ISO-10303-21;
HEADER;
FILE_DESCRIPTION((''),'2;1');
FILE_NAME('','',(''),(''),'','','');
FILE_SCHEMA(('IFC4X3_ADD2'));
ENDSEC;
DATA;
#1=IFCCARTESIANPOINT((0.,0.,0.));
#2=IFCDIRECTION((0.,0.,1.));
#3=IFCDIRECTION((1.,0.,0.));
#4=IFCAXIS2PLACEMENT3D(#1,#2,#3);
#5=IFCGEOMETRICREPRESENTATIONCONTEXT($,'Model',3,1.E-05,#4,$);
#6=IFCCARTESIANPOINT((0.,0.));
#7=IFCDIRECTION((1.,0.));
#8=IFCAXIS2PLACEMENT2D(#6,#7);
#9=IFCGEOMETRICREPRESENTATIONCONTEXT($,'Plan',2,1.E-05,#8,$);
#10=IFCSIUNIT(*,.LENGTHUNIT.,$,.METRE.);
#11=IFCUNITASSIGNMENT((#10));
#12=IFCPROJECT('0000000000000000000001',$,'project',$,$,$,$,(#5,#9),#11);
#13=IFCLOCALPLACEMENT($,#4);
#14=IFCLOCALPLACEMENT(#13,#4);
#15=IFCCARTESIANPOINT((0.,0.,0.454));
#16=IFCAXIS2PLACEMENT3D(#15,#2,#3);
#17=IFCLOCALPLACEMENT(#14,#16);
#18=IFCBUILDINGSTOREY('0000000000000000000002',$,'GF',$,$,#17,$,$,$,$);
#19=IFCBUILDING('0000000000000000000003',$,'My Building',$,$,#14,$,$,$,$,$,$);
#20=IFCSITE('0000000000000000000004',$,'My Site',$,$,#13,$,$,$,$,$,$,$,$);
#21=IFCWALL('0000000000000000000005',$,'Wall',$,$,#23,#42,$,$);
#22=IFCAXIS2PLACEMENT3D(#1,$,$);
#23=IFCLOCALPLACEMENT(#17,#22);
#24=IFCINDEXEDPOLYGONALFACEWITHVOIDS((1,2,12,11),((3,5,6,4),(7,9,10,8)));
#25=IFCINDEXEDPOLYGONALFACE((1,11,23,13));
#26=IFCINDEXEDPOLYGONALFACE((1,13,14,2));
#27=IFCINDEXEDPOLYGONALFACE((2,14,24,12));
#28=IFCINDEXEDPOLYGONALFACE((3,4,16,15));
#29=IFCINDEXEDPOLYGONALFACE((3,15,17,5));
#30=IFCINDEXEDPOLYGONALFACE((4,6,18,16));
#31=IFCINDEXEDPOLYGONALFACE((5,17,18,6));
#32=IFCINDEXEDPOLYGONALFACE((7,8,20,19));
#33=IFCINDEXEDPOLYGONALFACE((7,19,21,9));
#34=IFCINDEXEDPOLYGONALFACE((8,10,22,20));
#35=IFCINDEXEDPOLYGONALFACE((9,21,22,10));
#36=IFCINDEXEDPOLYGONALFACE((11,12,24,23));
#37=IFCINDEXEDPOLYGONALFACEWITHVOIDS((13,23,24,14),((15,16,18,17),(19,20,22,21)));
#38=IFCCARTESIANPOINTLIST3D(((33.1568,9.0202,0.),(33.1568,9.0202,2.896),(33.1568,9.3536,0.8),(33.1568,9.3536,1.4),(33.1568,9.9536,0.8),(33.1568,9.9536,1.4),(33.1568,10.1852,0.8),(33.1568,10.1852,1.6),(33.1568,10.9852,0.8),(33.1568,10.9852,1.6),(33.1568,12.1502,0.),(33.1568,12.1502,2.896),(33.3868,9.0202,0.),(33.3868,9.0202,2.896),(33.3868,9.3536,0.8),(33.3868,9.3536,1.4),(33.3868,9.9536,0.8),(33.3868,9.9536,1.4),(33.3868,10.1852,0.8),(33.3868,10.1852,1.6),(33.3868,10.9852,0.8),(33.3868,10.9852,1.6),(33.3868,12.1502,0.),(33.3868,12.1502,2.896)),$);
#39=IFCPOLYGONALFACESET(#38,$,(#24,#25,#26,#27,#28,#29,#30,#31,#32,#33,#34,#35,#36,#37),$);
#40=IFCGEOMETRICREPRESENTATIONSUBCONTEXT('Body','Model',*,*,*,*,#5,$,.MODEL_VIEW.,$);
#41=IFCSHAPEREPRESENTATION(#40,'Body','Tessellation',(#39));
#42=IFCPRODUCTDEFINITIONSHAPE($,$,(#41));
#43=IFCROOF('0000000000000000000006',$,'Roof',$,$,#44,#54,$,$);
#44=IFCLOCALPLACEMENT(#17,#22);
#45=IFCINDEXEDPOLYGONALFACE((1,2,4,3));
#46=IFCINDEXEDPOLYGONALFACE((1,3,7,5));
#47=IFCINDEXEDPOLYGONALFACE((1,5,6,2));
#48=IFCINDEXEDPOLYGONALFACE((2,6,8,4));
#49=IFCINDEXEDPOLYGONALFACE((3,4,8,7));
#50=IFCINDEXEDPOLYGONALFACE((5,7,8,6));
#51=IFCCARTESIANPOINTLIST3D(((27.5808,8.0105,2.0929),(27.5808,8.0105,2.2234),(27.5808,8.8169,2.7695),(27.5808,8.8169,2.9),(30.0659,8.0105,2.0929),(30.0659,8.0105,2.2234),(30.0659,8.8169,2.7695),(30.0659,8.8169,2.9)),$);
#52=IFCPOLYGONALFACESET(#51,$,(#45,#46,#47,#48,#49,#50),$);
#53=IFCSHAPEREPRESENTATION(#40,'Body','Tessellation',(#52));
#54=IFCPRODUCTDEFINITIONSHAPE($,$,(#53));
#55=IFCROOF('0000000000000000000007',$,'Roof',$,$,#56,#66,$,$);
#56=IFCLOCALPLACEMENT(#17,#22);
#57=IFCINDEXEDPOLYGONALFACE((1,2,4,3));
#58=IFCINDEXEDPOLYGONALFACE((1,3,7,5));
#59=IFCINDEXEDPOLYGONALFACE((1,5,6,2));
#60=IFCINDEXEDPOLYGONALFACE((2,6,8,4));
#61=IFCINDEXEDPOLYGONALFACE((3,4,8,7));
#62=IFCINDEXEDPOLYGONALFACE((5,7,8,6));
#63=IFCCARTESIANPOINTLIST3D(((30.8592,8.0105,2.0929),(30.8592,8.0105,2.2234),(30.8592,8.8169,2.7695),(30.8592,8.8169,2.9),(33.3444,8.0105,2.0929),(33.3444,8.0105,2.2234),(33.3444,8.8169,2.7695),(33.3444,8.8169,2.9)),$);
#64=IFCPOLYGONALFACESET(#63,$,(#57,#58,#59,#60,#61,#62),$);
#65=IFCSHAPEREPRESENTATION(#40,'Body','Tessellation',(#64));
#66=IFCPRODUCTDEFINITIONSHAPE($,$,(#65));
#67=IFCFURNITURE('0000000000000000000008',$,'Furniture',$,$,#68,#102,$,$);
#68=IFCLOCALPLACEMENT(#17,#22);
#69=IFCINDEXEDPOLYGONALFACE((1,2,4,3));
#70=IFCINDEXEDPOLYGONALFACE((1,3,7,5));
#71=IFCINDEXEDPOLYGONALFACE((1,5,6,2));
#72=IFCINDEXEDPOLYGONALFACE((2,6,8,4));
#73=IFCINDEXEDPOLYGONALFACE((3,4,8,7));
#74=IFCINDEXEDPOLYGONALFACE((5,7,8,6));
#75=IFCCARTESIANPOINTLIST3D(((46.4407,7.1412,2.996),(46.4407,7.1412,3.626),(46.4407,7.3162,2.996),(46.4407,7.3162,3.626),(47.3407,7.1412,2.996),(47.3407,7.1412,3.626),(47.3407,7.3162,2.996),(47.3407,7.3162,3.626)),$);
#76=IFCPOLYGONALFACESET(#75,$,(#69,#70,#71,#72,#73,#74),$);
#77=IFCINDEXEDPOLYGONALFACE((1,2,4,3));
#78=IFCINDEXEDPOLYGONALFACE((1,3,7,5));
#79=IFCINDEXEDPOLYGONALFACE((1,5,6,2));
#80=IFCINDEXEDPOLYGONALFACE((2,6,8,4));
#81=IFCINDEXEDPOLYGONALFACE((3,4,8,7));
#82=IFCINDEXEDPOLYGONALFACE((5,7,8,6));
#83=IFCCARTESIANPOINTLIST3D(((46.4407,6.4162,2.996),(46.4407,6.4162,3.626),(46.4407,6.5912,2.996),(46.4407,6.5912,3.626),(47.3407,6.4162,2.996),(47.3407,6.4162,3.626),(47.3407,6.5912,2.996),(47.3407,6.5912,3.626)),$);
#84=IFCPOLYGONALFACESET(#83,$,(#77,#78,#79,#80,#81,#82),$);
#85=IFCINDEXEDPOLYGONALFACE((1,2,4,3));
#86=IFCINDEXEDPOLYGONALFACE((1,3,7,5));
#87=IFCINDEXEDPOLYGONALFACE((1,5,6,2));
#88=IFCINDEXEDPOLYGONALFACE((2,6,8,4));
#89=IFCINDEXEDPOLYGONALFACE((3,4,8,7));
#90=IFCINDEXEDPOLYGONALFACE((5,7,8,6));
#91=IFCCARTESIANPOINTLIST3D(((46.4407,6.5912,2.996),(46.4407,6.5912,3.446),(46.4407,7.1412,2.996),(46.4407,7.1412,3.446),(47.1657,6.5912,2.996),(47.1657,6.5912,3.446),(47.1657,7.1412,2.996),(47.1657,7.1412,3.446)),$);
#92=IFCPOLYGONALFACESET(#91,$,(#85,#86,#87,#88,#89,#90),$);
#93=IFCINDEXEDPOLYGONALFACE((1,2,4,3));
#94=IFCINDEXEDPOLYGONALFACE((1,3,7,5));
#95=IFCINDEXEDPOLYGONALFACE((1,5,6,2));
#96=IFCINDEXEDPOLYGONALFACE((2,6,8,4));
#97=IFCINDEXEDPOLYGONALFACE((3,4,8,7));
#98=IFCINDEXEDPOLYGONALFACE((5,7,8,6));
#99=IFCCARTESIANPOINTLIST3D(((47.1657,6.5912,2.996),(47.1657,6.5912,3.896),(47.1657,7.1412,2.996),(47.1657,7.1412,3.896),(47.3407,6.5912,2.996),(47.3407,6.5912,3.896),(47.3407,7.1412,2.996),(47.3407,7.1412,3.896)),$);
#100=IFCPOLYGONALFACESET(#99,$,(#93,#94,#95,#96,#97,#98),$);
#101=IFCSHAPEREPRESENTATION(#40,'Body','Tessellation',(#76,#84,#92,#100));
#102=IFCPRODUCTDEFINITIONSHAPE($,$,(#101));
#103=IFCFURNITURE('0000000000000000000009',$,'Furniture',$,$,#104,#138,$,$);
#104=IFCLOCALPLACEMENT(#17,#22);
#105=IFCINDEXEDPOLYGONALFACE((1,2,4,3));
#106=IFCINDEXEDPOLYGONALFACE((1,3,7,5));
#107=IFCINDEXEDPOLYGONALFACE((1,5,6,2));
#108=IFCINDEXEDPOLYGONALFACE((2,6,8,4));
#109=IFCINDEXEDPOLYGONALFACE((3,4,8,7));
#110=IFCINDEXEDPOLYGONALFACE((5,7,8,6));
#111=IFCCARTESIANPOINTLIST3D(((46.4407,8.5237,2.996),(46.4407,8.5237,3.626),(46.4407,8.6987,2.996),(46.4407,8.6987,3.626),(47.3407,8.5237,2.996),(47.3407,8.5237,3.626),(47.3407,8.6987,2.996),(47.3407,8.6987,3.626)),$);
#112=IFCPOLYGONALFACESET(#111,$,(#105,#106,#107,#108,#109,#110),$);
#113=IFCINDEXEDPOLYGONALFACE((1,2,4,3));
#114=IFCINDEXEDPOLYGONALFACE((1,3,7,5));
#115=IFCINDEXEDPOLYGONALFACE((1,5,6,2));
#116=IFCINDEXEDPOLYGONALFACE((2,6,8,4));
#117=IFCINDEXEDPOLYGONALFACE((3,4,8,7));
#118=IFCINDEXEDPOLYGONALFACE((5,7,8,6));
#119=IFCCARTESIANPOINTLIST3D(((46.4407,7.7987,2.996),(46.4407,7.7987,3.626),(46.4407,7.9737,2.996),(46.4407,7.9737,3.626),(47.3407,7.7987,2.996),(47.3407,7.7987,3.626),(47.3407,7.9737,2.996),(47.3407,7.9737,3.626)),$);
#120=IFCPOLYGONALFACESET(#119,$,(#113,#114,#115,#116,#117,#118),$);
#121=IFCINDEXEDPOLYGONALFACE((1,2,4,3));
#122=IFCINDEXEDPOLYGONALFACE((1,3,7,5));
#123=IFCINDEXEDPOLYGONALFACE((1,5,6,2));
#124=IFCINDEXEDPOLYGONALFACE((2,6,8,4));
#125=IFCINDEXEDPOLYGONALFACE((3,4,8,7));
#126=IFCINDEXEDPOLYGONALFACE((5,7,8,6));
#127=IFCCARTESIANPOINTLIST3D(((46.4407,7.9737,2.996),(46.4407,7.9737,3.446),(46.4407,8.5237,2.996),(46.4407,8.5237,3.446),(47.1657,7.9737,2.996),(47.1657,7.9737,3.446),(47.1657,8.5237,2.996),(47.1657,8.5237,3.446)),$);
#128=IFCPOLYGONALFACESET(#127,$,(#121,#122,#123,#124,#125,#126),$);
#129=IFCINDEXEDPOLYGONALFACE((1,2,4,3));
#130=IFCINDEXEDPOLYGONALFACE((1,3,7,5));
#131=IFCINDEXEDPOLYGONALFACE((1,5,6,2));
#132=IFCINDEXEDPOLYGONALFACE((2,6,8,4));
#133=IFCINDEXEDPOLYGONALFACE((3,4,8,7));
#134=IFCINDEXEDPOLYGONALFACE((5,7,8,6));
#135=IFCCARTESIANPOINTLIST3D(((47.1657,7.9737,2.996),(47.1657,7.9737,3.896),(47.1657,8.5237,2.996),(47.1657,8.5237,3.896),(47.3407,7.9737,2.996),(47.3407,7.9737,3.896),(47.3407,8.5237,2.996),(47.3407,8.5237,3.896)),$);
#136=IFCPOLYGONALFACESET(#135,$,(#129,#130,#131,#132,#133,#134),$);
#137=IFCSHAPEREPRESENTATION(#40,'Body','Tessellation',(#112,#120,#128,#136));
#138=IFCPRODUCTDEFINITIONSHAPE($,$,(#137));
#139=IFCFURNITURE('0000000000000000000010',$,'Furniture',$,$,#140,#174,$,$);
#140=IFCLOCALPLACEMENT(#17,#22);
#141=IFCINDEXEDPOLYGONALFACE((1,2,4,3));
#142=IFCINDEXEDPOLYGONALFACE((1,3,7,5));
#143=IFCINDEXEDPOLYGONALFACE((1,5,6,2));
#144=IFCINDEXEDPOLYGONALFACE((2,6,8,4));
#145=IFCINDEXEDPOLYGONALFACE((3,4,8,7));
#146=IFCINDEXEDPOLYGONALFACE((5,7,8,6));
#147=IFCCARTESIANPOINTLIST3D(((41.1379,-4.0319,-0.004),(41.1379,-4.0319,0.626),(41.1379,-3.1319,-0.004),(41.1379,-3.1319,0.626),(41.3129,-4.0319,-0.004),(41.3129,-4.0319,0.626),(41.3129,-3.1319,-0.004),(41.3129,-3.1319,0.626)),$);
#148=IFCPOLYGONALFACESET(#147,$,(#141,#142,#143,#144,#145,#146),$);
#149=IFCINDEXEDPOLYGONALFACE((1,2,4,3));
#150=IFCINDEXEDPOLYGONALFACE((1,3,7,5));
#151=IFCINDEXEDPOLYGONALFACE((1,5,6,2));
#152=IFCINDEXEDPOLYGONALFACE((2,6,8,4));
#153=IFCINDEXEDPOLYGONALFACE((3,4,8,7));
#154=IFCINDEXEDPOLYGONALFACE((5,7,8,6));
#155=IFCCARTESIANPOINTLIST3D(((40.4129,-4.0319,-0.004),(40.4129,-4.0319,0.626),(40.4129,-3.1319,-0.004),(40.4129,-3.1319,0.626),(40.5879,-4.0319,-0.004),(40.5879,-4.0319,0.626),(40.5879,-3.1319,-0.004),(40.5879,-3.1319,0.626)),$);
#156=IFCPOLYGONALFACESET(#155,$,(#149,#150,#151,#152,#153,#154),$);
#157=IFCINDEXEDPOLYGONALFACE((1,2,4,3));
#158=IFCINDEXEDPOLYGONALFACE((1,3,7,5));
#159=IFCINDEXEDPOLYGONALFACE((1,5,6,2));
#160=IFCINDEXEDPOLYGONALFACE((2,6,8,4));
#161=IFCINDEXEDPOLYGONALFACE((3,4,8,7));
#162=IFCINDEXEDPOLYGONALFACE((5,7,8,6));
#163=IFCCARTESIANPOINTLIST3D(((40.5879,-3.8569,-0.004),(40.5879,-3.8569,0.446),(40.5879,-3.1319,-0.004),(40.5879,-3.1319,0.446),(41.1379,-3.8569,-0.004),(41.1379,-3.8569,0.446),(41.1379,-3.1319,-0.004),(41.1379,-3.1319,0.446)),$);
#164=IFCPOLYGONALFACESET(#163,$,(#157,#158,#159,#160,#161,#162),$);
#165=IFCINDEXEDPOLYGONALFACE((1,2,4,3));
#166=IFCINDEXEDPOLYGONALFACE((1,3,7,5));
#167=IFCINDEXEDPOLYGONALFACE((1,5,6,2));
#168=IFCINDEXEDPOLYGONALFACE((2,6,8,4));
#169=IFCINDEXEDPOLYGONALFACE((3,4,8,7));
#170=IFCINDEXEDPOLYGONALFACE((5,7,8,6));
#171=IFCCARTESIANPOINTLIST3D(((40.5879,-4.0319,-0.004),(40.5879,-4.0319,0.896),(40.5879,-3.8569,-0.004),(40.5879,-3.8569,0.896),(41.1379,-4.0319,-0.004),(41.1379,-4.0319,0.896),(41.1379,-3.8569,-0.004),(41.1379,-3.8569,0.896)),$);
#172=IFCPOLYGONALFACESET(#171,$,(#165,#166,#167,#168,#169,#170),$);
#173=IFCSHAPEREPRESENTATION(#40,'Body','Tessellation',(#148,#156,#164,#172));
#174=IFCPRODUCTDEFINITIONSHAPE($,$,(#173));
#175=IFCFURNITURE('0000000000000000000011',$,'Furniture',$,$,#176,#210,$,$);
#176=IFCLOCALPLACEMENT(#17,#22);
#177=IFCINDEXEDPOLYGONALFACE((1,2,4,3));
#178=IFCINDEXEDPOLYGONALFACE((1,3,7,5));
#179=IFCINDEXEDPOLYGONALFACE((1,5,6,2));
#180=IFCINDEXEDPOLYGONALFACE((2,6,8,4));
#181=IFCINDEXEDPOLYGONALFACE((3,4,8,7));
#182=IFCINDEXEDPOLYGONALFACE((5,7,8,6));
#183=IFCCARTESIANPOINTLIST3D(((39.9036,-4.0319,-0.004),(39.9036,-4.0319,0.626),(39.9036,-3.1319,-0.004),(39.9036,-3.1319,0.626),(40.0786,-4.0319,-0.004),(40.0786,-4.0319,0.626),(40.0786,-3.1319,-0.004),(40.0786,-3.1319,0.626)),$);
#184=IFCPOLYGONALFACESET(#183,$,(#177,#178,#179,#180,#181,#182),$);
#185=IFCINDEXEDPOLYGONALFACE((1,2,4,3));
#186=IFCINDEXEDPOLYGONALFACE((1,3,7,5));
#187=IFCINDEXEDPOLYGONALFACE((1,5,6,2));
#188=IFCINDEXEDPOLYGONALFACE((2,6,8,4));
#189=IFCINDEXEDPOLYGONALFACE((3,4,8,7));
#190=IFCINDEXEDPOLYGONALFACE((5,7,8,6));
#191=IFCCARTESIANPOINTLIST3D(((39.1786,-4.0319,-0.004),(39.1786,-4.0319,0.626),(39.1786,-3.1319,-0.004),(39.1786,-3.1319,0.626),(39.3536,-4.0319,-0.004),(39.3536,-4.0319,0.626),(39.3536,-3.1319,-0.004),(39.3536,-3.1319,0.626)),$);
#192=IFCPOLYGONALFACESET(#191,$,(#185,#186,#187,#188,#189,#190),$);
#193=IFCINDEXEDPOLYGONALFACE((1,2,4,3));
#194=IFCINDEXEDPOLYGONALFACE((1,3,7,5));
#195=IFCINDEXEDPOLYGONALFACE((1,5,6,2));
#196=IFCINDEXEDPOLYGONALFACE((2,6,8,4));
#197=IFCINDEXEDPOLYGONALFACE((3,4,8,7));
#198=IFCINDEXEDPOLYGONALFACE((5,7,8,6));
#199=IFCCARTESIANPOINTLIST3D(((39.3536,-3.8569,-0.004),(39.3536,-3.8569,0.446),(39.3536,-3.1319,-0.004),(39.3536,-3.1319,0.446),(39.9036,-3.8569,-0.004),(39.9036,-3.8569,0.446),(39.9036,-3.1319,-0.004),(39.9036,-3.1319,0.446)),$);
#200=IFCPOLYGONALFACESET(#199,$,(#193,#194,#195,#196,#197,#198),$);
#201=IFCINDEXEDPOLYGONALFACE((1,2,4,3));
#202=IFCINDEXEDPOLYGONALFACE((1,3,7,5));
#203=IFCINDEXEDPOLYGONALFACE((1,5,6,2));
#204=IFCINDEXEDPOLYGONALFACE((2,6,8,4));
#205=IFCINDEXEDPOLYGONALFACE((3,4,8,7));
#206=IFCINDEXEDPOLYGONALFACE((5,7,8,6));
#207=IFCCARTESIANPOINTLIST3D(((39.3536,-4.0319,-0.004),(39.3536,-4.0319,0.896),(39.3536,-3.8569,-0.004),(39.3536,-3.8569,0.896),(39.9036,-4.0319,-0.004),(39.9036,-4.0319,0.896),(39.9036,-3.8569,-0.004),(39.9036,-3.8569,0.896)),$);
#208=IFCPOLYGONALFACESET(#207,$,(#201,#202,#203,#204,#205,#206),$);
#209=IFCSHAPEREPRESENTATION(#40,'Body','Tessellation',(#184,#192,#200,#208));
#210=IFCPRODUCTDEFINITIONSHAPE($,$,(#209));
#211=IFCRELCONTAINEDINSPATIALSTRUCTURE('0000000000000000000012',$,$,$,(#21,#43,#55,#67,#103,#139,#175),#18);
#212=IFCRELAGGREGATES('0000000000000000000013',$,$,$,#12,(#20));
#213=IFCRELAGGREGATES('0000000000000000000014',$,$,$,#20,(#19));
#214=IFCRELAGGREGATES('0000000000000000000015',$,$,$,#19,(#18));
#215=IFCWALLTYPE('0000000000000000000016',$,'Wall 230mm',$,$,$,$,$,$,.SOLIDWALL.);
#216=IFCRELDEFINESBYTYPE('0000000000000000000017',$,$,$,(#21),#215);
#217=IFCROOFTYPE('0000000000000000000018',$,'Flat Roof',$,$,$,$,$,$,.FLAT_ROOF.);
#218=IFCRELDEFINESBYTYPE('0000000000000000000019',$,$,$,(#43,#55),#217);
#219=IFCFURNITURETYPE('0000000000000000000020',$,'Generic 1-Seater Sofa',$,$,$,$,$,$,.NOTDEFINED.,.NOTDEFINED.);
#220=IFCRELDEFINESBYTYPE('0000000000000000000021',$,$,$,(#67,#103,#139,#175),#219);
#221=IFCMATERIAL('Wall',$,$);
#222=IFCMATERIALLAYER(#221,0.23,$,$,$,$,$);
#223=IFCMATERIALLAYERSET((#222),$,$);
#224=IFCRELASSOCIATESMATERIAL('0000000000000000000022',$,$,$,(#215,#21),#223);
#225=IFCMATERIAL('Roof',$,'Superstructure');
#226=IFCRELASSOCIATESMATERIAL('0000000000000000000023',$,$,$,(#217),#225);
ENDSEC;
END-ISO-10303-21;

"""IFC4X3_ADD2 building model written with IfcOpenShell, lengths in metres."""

from ifc_helpers import new_model, entity, si_unit, frame, origin_with_axes, origin_2d_with_axis, place, context, subcontext, project, spatial, polyline, line, indexed_curve, outline, extrude, clip, halfspace, shape, source, transform, mapped, material, layer, layer_set, layer_usage, type_object, type_shapes, element, save


model = new_model("IFC4X3_ADD2")

# Units and contexts
model_context = context("Model", 3, precision=1e-05, world=origin_with_axes())
plan_context = context("Plan", 2, precision=1e-05, world=origin_2d_with_axis())
body_context_1 = subcontext(model_context, "Body", "Model", "MODEL_VIEW")
body_context_2 = subcontext(plan_context, "Body", "Plan", "PLAN_VIEW")
ifc_project = project(units=[si_unit("LENGTHUNIT", "METRE")], contexts=[model_context, plan_context])

# Site, building, storey
site_placement = place(None, origin_with_axes())
site = spatial("IfcSite", under=ifc_project, at=site_placement, Name="My Site")
building_placement = place(site_placement, origin_with_axes())
building = spatial("IfcBuilding", under=site, at=building_placement, Name="My Building")
storey_placement = place(building_placement, frame((0.0, 0.0, 0.454), z_axis=(0.0, 0.0, 1.0), x_axis=(1.0, 0.0, 0.0)))
storey = spatial("IfcBuildingStorey", under=building, at=storey_placement, Name="GF")

# Shared definitions
ifc_material_1 = material(Name="Wall")
ifc_layer = layer(ifc_material_1, 0.23)
ifc_layer_set = layer_set([ifc_layer])
wall_type = type_object("IfcWallType", Name="Wall 230mm", PredefinedType="SOLIDWALL", material=ifc_layer_set)
shared_shape_1 = source(origin_with_axes(), body_context_1, "Body", "SweptSolid", [
    extrude(outline(indexed_curve([(0.0, 0.0), (0.6, 0.0), (0.6, 0.6), (0.0, 0.6)], segments=[line(1, 2, 3, 4, 1)])), frame((-0.3, -0.6, 0.0), z_axis=(0.0, -1.0, 0.0), x_axis=(1.0, 0.0, 0.0)), (0.0, 0.0, -1.0), 1.2),
])

# Wall, openings
ifc_layer_usage_1 = layer_usage(ifc_layer_set, "AXIS2", "POSITIVE", 0.0)
wall_1_placement = place(storey_placement, frame((33.3868, 9.0202, 0.0), z_axis=(0.0, 0.0, 1.0), x_axis=(0.000001, 1.0, 0.0)))
wall_1 = element("IfcWall", 1, at=wall_1_placement, inside=storey, type_object=wall_type, material=ifc_layer_usage_1, Name="Wall", context=body_context_1, shape_type="Clipping", body=[
    clip(extrude(outline(indexed_curve([(0.0, 0.0), (0.0, 0.23), (3.13, 0.23), (3.13, 0.0), (0.0, 0.0)], self_intersect=False)), origin_with_axes(), (0.0, 0.0, 1.0), 3.35), halfspace(frame((0.0, 0.0, 2.896), z_axis=(0.0, 0.0, 1.0), x_axis=(-1.0, 0.0, 0.0)), False)),
])
opening_1_placement = place(wall_1_placement, frame((0.6334, 0.0, 0.8), z_axis=(0.0, 0.0, 1.0), x_axis=(1.0, 0.0, 0.0)))
element("IfcOpeningElement", 2, at=opening_1_placement, cuts=wall_1, PredefinedType="OPENING", context=body_context_1, shape_type="MappedRepresentation", body=[
    mapped(shared_shape_1, transform((0.0, 0.0, 0.0), x_axis=(1.0, 0.0, 0.0), y_axis=(0.0, 1.0, 0.0), z_axis=(0.0, 0.0, 1.0), scale=1.0)),
])
shared_shape_2 = source(origin_with_axes(), body_context_1, "Body", "SweptSolid", [
    extrude(outline(indexed_curve([(0.0, 0.0), (0.8, 0.0), (0.8, 0.8), (0.0, 0.8)], segments=[line(1, 2, 3, 4, 1)])), frame((-0.4, -0.6, 0.0), z_axis=(0.0, -1.0, 0.0), x_axis=(1.0, 0.0, 0.0)), (0.0, 0.0, -1.0), 1.2),
])
opening_2_placement = place(wall_1_placement, frame((1.565, 0.0, 0.8), z_axis=(0.0, 0.0, 1.0), x_axis=(1.0, 0.0, 0.0)))
element("IfcOpeningElement", 3, at=opening_2_placement, cuts=wall_1, PredefinedType="OPENING", context=body_context_1, shape_type="MappedRepresentation", body=[
    mapped(shared_shape_2, transform((0.0, 0.0, 0.0), x_axis=(1.0, 0.0, 0.0), y_axis=(0.0, 1.0, 0.0), z_axis=(0.0, 0.0, 1.0), scale=1.0)),
])

# Roofs
ifc_material_2 = material(Name="Roof", Category="Superstructure")
roof_type = type_object("IfcRoofType", Name="Flat Roof", PredefinedType="FLAT_ROOF", material=ifc_material_2)
for number, where, z_axis, x_axis, name in (
    (4, (27.5808, 8.0241, 2.1043), (0.0, -0.642788, 0.766044), (1.0, 0.0, 0.0), "Roof"),
    (5, (30.8592, 8.0241, 2.1043), (0.0, -0.642788, 0.766044), (1.0, 0.0, 0.0), "Roof"),
):
    element("IfcRoof", number, at=place(storey_placement, frame(where, z_axis=z_axis, x_axis=x_axis)), inside=storey, type_object=roof_type, Name=name, context=body_context_1, shape_type="SweptSolid", body=[
        extrude(outline(polyline([(-1.2426, -0.0653), (1.2426, -0.0653), (1.2426, 0.0653), (-1.2426, 0.0653), (-1.2426, -0.0653)])), frame((1.2426, 1.0768, 0.05), z_axis=(0.0, 0.766044, -0.642788), x_axis=(1.0, 0.0, 0.0)), (0.0, 0.642788, -0.766044), 1.0526),
    ])

# Furniture
furniture_type_1 = type_object("IfcFurnitureType", Name="Generic 1-Seater Sofa", AssemblyPlace="NOTDEFINED", PredefinedType="NOTDEFINED")
shared_shape_3 = source(origin_with_axes(), body_context_1, "Body", "SweptSolid", [
    extrude(outline(indexed_curve([(0.0, 0.0), (0.175, 0.0), (0.175, 0.9), (0.0, 0.9)], segments=[line(4, 1), line(1, 2), line(2, 3), line(3, 4)], self_intersect=False)), frame((-0.45, -0.9, 0.0), z_axis=(0.0, 0.0, 1.0), x_axis=(1.0, 0.0, 0.0)), (0.0, 0.0, 1.0), 0.63),
    extrude(outline(indexed_curve([(0.0, 0.0), (0.175, 0.0), (0.175, 0.9), (0.0, 0.9)], segments=[line(1, 2, 3, 4, 1)])), frame((0.275, -0.9, 0.0), z_axis=(0.0, 0.0, 1.0), x_axis=(1.0, 0.0, 0.0)), (0.0, 0.0, 1.0), 0.63),
    extrude(outline(indexed_curve([(0.175, 0.0), (0.725, 0.0), (0.725, 0.725), (0.175, 0.725)], segments=[line(1, 2, 3, 4, 1)])), frame((-0.45, -0.9, 0.0), z_axis=(0.0, 0.0, 1.0), x_axis=(1.0, 0.0, 0.0)), (0.0, 0.0, 1.0), 0.45),
    extrude(outline(indexed_curve([(0.175, 0.725), (0.725, 0.725), (0.725, 0.9), (0.175, 0.9)], segments=[line(1, 2, 3, 4, 1)])), frame((-0.45, -0.9, 0.0), z_axis=(0.0, 0.0, 1.0), x_axis=(1.0, 0.0, 0.0)), (0.0, 0.0, 1.0), 0.9),
])
shared_shape_4 = source(origin_with_axes(), body_context_2, "Body", "Annotation2D", [
    entity("IfcGeometricCurveSet", [entity("IfcIndexedPolyCurve", entity("IfcCartesianPointList2D", [[0.275, -0.175], [0.275, -0.9], [0.45, -0.9], [0.45, 0.0], [0.275, 0.0], [0.275, -0.9], [-0.275, -0.9], [-0.275, 0.0], [-0.275, -0.175], [0.275, -0.175], [0.275, 0.0], [-0.275, 0.0], [-0.45, 0.0], [-0.45, -0.9], [-0.275, -0.9], [-0.275, -0.175]]))]),
])
type_shapes(furniture_type_1, [shared_shape_3, shared_shape_4])
for number, where, z_axis, x_axis, name in (
    (6, (47.3407, 6.8662, 2.996), (0.0, 0.0, 1.0), (0.0, -1.0, 0.0), "Furniture"),
    (7, (47.3407, 8.2487, 2.996), (0.0, 0.0, 1.0), (0.0, -1.0, 0.0), "Furniture"),
    (8, (40.8629, -4.0319, -0.004), (0.0, 0.0, 1.0), (-1.0, 0.0, 0.0), "Furniture"),
    (9, (39.6286, -4.0319, -0.004), (0.0, 0.0, 1.0), (-1.0, 0.0, 0.0), "Furniture"),
):
    element("IfcFurniture", number, at=place(storey_placement, frame(where, z_axis=z_axis, x_axis=x_axis)), inside=storey, type_object=furniture_type_1, Name=name, shapes=[
        shape(body_context_1, "Body", "MappedRepresentation", [mapped(shared_shape_3, transform((0.0, 0.0, 0.0), x_axis=(1.0, 0.0, 0.0), y_axis=(0.0, 1.0, 0.0), z_axis=(0.0, 0.0, 1.0), scale=1.0))]),
        shape(body_context_2, "Body", "MappedRepresentation", [mapped(shared_shape_4, transform((0.0, 0.0, 0.0), x_axis=(1.0, 0.0, 0.0), y_axis=(0.0, 1.0, 0.0), z_axis=(0.0, 0.0, 1.0), scale=1.0))]),
    ])

save(model, "model.ifc")
